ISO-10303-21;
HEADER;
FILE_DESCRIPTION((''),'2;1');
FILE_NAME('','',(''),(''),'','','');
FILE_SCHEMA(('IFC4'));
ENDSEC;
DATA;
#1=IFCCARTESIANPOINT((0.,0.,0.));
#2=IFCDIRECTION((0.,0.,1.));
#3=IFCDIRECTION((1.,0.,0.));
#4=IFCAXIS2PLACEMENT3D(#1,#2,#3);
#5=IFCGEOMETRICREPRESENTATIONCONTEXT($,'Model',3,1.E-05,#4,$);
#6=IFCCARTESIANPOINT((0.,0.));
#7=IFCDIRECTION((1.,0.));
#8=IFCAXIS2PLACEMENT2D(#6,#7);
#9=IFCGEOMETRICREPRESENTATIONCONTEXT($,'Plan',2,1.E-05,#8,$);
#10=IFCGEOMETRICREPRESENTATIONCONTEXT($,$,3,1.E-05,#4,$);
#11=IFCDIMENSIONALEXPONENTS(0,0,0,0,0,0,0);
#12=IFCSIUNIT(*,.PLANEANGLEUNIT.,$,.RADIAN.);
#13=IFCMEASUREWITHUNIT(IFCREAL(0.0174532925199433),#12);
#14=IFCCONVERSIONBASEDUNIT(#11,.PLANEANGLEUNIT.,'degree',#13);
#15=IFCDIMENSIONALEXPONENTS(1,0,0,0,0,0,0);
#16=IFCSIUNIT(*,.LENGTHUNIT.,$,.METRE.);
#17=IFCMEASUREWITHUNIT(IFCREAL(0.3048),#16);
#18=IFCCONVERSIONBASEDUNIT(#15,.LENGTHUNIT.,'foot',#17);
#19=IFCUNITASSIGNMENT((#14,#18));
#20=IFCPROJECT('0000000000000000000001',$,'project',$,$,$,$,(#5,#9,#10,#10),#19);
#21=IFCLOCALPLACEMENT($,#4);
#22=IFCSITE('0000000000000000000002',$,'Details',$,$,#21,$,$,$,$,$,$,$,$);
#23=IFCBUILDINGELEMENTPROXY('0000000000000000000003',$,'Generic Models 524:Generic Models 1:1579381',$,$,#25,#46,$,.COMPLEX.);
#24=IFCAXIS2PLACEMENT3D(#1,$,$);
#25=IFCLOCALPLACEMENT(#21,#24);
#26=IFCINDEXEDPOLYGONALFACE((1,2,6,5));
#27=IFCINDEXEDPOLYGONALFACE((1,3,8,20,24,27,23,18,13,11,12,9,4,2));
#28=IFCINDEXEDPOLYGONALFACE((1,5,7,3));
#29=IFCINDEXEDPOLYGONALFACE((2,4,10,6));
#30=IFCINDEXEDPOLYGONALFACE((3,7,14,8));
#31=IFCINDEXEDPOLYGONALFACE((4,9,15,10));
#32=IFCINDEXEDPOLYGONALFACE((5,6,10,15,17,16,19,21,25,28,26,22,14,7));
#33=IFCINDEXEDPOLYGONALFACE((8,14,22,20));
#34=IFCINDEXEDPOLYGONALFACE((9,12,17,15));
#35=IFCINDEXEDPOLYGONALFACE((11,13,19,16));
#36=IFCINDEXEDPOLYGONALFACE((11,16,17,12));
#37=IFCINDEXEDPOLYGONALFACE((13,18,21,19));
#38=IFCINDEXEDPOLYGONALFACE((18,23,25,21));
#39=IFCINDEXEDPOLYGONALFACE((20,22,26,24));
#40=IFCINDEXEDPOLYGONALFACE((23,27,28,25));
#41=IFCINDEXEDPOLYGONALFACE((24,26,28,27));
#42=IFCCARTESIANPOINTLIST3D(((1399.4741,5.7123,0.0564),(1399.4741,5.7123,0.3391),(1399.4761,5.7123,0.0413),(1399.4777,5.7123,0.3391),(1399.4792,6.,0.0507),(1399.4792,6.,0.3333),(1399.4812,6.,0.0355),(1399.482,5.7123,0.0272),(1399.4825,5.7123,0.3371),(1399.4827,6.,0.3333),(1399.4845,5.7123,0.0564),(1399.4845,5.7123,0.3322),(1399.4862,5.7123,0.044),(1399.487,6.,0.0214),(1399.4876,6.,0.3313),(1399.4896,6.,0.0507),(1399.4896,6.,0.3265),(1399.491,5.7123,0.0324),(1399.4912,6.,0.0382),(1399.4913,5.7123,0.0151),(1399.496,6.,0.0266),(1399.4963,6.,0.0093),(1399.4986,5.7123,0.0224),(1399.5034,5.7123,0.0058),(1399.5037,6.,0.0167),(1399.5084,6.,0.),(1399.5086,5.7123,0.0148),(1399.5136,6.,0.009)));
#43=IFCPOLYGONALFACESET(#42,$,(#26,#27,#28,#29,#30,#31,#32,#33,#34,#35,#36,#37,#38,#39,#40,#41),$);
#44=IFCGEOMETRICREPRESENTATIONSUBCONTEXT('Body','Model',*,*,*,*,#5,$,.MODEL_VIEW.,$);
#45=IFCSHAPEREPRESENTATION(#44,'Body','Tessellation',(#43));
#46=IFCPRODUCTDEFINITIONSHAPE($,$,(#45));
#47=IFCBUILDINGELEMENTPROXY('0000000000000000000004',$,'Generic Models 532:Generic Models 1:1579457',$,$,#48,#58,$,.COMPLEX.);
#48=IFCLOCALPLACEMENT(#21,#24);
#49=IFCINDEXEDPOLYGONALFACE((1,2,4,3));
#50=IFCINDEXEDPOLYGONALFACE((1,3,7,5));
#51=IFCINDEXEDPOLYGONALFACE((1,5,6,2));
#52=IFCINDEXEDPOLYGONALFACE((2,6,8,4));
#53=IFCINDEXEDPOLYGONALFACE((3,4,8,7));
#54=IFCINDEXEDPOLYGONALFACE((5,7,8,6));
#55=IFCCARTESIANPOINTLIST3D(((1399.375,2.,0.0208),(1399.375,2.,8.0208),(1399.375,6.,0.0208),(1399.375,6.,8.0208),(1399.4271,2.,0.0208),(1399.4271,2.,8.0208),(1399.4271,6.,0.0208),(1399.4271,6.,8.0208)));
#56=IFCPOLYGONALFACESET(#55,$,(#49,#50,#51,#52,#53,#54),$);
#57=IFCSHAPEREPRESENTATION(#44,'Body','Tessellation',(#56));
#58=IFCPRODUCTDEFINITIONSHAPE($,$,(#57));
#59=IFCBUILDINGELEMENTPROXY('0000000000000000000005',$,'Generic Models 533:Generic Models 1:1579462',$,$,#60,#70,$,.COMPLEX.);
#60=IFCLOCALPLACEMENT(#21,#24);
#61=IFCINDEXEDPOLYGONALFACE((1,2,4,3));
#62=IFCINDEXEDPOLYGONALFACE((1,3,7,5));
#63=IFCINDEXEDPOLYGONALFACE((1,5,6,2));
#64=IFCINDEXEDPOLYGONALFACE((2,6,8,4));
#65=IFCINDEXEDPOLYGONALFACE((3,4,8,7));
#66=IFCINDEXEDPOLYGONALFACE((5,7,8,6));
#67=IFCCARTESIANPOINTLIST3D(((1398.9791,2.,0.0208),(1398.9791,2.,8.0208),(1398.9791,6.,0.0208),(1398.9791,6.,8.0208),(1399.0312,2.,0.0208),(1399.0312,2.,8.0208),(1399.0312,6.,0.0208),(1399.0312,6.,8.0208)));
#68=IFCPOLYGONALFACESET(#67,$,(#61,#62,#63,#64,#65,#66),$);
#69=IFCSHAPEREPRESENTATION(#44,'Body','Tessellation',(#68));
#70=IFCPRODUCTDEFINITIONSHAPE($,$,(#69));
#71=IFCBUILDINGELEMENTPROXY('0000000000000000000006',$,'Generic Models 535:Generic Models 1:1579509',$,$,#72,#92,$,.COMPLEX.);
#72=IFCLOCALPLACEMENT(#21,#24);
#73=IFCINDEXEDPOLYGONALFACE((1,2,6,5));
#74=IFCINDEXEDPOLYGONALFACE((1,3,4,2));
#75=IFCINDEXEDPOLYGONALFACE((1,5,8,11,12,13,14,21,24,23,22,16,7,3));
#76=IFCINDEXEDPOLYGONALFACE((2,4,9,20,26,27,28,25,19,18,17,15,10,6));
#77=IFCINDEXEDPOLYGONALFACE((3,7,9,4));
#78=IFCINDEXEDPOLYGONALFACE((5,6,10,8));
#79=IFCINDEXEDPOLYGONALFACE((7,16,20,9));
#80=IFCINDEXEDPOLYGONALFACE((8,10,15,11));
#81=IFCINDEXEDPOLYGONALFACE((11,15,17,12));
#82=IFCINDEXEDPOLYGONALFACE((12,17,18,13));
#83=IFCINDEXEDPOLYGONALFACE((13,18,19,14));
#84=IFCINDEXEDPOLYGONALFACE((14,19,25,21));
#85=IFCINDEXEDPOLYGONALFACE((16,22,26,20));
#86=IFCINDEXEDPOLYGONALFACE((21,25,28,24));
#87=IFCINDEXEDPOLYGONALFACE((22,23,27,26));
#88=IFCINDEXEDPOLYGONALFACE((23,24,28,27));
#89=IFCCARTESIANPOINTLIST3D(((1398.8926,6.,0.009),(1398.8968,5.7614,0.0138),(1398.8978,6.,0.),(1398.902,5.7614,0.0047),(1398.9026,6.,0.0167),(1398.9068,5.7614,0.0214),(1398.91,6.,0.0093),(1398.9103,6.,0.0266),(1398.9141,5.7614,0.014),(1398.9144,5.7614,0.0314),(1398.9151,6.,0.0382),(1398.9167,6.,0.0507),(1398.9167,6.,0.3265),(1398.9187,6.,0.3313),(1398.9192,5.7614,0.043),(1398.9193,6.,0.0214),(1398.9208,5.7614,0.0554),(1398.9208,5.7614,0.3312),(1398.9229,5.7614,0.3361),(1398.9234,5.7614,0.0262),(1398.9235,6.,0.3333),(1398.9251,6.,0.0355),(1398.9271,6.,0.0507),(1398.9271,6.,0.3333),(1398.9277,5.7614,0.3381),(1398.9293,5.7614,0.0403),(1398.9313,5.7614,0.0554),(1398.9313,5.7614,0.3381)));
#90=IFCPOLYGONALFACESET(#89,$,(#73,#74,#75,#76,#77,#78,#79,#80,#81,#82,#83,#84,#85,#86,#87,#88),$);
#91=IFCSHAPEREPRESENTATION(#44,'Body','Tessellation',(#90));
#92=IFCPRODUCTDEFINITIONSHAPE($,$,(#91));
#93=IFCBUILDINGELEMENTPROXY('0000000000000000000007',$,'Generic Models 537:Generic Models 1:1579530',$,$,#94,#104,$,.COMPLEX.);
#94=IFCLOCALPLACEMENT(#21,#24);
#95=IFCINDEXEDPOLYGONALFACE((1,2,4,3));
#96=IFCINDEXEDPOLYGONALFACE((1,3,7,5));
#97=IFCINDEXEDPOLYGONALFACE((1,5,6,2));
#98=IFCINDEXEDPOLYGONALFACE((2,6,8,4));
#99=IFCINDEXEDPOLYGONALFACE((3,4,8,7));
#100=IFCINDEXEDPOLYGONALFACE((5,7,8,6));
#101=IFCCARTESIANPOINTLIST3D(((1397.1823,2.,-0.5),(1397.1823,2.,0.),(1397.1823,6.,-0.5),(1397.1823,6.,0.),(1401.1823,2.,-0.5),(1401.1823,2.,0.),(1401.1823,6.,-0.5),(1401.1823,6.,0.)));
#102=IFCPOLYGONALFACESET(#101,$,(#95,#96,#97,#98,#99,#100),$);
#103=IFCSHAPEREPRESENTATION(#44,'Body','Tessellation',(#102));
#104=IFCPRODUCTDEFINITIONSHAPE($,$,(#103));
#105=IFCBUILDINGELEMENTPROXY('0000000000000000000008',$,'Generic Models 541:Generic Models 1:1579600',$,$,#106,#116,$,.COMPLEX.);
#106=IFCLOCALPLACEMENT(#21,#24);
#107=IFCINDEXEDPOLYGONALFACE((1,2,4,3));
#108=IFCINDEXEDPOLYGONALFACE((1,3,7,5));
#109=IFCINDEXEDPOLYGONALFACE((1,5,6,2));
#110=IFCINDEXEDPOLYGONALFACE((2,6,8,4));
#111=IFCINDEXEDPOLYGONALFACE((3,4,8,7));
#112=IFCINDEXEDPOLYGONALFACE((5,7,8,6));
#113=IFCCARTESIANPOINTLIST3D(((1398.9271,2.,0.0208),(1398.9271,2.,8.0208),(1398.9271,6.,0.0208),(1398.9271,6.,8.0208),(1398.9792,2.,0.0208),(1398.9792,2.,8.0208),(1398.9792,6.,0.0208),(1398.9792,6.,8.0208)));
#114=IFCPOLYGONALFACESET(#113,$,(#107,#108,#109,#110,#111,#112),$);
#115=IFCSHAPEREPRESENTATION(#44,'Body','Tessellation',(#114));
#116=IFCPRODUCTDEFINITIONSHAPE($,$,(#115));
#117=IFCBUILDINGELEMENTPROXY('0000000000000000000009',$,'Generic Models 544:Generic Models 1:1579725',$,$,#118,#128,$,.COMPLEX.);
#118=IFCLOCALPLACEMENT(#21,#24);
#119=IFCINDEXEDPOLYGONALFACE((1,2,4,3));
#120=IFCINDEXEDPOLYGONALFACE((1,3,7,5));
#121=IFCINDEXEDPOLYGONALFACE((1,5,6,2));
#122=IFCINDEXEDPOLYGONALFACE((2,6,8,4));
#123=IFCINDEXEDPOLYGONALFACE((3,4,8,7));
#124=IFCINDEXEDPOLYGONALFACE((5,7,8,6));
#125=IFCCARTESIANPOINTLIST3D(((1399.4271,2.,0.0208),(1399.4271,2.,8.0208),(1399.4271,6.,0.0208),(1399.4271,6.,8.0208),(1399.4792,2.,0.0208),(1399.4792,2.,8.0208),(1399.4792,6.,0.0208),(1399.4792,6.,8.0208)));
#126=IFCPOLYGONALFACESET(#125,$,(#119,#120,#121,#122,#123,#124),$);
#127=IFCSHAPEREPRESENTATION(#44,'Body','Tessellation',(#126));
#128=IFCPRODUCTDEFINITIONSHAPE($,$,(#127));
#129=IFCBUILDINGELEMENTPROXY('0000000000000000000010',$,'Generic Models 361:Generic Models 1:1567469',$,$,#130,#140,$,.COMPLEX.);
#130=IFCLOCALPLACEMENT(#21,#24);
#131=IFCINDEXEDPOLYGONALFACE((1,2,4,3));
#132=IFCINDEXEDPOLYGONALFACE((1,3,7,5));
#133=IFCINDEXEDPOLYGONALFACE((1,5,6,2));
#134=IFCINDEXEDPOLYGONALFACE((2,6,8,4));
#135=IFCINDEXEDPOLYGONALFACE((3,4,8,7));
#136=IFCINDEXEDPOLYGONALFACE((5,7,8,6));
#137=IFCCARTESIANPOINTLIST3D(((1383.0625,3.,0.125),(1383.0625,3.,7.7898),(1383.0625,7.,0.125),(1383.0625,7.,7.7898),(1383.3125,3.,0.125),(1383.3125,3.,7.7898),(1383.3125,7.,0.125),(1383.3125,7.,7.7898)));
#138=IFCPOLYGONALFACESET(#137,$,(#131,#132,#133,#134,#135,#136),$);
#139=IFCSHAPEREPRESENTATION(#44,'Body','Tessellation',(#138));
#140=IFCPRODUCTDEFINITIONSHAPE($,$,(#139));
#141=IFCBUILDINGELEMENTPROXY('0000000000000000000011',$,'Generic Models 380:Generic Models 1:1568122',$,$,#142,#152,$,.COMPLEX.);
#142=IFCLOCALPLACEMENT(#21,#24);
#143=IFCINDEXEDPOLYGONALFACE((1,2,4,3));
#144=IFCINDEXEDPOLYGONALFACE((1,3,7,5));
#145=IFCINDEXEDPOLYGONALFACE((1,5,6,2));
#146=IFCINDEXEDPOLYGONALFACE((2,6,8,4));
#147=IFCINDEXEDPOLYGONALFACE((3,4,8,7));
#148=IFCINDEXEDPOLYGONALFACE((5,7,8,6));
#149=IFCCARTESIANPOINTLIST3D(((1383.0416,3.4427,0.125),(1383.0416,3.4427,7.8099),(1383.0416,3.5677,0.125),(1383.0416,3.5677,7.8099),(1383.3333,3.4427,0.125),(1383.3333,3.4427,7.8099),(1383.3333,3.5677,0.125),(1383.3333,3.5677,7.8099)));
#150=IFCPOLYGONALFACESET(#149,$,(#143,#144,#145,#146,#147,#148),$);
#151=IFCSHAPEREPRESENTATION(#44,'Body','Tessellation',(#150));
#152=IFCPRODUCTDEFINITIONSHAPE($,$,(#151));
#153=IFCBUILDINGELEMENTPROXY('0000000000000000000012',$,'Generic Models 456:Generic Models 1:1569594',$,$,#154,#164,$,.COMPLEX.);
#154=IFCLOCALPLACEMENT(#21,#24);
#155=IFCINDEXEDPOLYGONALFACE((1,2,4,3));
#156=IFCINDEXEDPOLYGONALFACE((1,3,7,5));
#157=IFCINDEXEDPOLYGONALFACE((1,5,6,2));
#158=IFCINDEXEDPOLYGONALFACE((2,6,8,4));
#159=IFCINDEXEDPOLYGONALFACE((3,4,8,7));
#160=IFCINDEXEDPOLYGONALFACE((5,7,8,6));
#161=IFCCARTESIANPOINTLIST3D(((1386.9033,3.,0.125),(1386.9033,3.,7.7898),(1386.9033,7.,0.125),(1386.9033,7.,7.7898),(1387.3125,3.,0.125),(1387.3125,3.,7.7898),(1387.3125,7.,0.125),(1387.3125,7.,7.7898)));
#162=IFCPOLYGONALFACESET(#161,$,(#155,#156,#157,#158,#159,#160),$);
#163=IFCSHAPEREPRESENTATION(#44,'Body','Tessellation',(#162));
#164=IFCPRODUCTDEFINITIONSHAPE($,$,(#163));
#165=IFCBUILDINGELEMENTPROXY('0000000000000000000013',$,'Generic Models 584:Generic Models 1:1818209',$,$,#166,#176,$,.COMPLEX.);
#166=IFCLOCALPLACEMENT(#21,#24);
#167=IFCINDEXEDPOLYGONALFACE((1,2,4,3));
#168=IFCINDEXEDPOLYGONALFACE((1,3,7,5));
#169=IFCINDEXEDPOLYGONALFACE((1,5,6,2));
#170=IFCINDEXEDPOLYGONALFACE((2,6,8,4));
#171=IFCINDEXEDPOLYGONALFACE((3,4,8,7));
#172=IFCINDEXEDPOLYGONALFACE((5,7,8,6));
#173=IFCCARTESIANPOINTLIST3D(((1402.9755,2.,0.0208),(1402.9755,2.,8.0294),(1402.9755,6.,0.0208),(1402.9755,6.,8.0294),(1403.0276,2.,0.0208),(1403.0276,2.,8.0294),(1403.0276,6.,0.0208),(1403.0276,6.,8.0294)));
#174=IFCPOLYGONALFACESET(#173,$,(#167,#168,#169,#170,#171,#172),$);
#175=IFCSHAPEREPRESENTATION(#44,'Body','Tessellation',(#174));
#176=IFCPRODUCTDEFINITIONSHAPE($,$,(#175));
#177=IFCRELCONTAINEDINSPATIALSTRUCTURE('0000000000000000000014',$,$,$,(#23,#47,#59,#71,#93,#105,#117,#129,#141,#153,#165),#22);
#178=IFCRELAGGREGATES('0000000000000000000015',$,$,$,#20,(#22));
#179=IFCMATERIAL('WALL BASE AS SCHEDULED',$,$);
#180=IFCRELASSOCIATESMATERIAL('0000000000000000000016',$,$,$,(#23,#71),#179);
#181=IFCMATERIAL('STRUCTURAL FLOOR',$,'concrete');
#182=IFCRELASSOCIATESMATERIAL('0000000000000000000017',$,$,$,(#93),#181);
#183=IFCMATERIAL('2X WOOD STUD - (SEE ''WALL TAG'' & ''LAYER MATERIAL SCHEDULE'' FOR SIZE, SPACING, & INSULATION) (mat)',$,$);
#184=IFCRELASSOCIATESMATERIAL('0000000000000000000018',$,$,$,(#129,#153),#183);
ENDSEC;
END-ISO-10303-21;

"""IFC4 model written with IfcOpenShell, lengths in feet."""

from ifc_helpers import new_model, entity, si_unit, converted_unit, frame, origin_with_axes, origin_2d_with_axis, place, context, subcontext, project, spatial, polyline, line, indexed_curve, outline, extrude, material, element, save


model = new_model("IFC4")

# Units and contexts
model_context = context("Model", 3, precision=1e-05, world=origin_with_axes())
plan_context = context("Plan", 2, precision=1e-05, world=origin_2d_with_axis())
context_of_model = context(None, 3, precision=1e-05, world=origin_with_axes())
body_context = subcontext(model_context, "Body", "Model", "MODEL_VIEW")
ifc_project = project(units=[converted_unit("PLANEANGLEUNIT", "degree", entity("IfcReal", 0.0174532925199433), si_unit("PLANEANGLEUNIT", "RADIAN"), dimensions=[0, 0, 0, 0, 0, 0, 0]), converted_unit("LENGTHUNIT", "foot", entity("IfcReal", 0.3048), si_unit("LENGTHUNIT", "METRE"), dimensions=[1, 0, 0, 0, 0, 0, 0])], contexts=[model_context, plan_context, context_of_model, context_of_model])

# Site
site_placement = place(None, origin_with_axes())
site = spatial("IfcSite", under=ifc_project, at=site_placement, Name="Details")

# Building element proxies
ifc_material_1 = material(Name="WALL BASE AS SCHEDULED")
proxy_1_placement = place(site_placement, frame((1399.4792, 6.0, 0.0), z_axis=(0.0, -1.0, 0.0), x_axis=(0.0, 0.0, 1.0)))
element("IfcBuildingElementProxy", 1, at=proxy_1_placement, inside=site, material=ifc_material_1, Name="Generic Models 524:Generic Models 1:1579381", PredefinedType="COMPLEX", context=body_context, shape_type="SweptSolid", body=[
    extrude(outline(polyline([(0.0865, 0.0), (0.0968, -0.0072), (0.105, -0.0167), (0.1137, -0.0111), (0.1038, 0.0006), (0.0913, 0.0093), (0.0769, 0.0144), (0.0617, 0.0157), (-0.2206, 0.0019), (-0.2205, -0.0017), (-0.2182, -0.0064), (-0.2133, -0.0082), (0.0622, 0.0053), (0.0747, 0.0042), (0.0865, 0.0)])), frame((0.113, -0.0126, 0.0), z_axis=(0.0, 0.0, -1.0), x_axis=(-0.998808, -0.048806, 0.0)), (-0.020832, 0.016543, -0.999646), 0.2878),
])
proxy_2_placement = place(site_placement, frame((1399.375, 6.0, 0.0208), z_axis=(0.0, -1.0, 0.0), x_axis=(0.0, 0.0, 1.0)))
element("IfcBuildingElementProxy", 2, at=proxy_2_placement, inside=site, Name="Generic Models 532:Generic Models 1:1579457", PredefinedType="COMPLEX", context=body_context, shape_type="SweptSolid", body=[
    extrude(outline(polyline([(-4.0, -0.026), (4.0, -0.026), (4.0, 0.026), (-4.0, 0.026), (-4.0, -0.026)])), frame((4.0, -0.026, 0.0), z_axis=(0.0, 0.0, -1.0), x_axis=(1.0, 0.0, 0.0)), (0.0, 0.0, -1.0), 4.0),
])
proxy_3_placement = place(site_placement, frame((1398.9791, 6.0, 0.0208), z_axis=(0.0, -1.0, 0.0), x_axis=(0.0, 0.0, 1.0)))
element("IfcBuildingElementProxy", 3, at=proxy_3_placement, inside=site, Name="Generic Models 533:Generic Models 1:1579462", PredefinedType="COMPLEX", context=body_context, shape_type="SweptSolid", body=[
    extrude(outline(polyline([(-0.026, -4.0), (0.026, -4.0), (0.026, 4.0), (-0.026, 4.0), (-0.026, -4.0)])), frame((4.0, -0.026, 0.0), z_axis=(0.0, 0.0, -1.0), x_axis=(0.0, -1.0, 0.0)), (0.0, 0.0, -1.0), 4.0),
])
proxy_4_placement = place(site_placement, frame((1398.8926, 6.0, 0.0), z_axis=(0.0, -1.0, 0.0), x_axis=(0.0, 0.0, 1.0)))
element("IfcBuildingElementProxy", 4, at=proxy_4_placement, inside=site, material=ifc_material_1, Name="Generic Models 535:Generic Models 1:1579509", PredefinedType="COMPLEX", context=body_context, shape_type="SweptSolid", body=[
    extrude(outline(polyline([(-0.2203, -0.0126), (0.0624, -0.0126), (0.0775, -0.0106), (0.0916, -0.0048), (0.1037, 0.0045), (0.113, 0.0166), (0.104, 0.0218), (0.0964, 0.0119), (0.0864, 0.0042), (0.0748, -0.0006), (0.0624, -0.0022), (-0.2134, -0.0022), (-0.2183, -0.0042), (-0.2203, -0.0091), (-0.2203, -0.0126)])), frame((0.113, -0.0218, 0.0), z_axis=(0.0, 0.0, -1.0), x_axis=(-1.0, 0.0, 0.0)), (-0.01982, -0.017382, -0.999652), 0.2387),
])
ifc_material_2 = material(Name="STRUCTURAL FLOOR", Category="concrete")
proxy_5_placement = place(site_placement, frame((1397.1823, 6.0, -0.5), z_axis=(0.0, -1.0, 0.0), x_axis=(0.0, 0.0, 1.0)))
element("IfcBuildingElementProxy", 5, at=proxy_5_placement, inside=site, material=ifc_material_2, Name="Generic Models 537:Generic Models 1:1579530", PredefinedType="COMPLEX", context=body_context, shape_type="SweptSolid", body=[
    extrude(outline(polyline([(-0.25, -2.0), (0.25, -2.0), (0.25, 2.0), (-0.25, 2.0), (-0.25, -2.0)])), frame((0.25, -2.0, 0.0), z_axis=(0.0, 0.0, -1.0), x_axis=(1.0, 0.0, 0.0)), (0.0, 0.0, -1.0), 4.0),
])
proxy_6_placement = place(site_placement, frame((1398.9271, 6.0, 0.0208), z_axis=(0.0, -1.0, 0.0), x_axis=(0.0, 0.0, 1.0)))
element("IfcBuildingElementProxy", 6, at=proxy_6_placement, inside=site, Name="Generic Models 541:Generic Models 1:1579600", PredefinedType="COMPLEX", context=body_context, shape_type="SweptSolid", body=[
    extrude(outline(polyline([(-4.0, -0.026), (4.0, -0.026), (4.0, 0.026), (-4.0, 0.026), (-4.0, -0.026)])), frame((4.0, -0.026, 0.0), z_axis=(0.0, 0.0, -1.0), x_axis=(1.0, 0.0, 0.0)), (0.0, 0.0, -1.0), 4.0),
])
proxy_7_placement = place(site_placement, frame((1399.4271, 6.0, 0.0208), z_axis=(0.0, -1.0, 0.0), x_axis=(0.0, 0.0, 1.0)))
element("IfcBuildingElementProxy", 7, at=proxy_7_placement, inside=site, Name="Generic Models 544:Generic Models 1:1579725", PredefinedType="COMPLEX", context=body_context, shape_type="SweptSolid", body=[
    extrude(outline(indexed_curve([(-4.0, -0.026), (4.0, -0.026), (4.0, 0.026), (-4.0, 0.026)], segments=[line(3, 2), line(2, 1), line(1, 4), line(4, 3)], self_intersect=False)), frame((4.0, -0.026, 0.0), z_axis=(0.0, 0.0, -1.0), x_axis=(1.0, 0.0, 0.0)), (0.0, 0.0, -1.0), 4.0),
])
ifc_material_3 = material(Name="2X WOOD STUD - (SEE 'WALL TAG' & 'LAYER MATERIAL SCHEDULE' FOR SIZE, SPACING, & INSULATION) (mat)")
proxy_8_placement = place(site_placement, frame((1383.0625, 7.0, 0.125), z_axis=(0.0, -1.0, 0.0), x_axis=(0.0, 0.0, 1.0)))
element("IfcBuildingElementProxy", 8, at=proxy_8_placement, inside=site, material=ifc_material_3, Name="Generic Models 361:Generic Models 1:1567469", PredefinedType="COMPLEX", context=body_context, shape_type="SweptSolid", body=[
    extrude(outline(polyline([(-0.125, -3.8324), (0.125, -3.8324), (0.125, 3.8324), (-0.125, 3.8324), (-0.125, -3.8324)])), frame((3.8324, -0.125, 0.0), z_axis=(0.0, 0.0, -1.0), x_axis=(0.0, -1.0, 0.0)), (0.0, 0.0, -1.0), 4.0),
])
proxy_9_placement = place(site_placement, frame((1383.0416, 7.4427, 0.125), z_axis=(0.0, -1.0, 0.0), x_axis=(1.0, 0.0, 0.0)))
element("IfcBuildingElementProxy", 9, at=proxy_9_placement, inside=site, Name="Generic Models 380:Generic Models 1:1568122", PredefinedType="COMPLEX", context=body_context, shape_type="SweptSolid", body=[
    extrude(outline(polyline([(-0.1458, -3.8424), (0.1458, -3.8424), (0.1458, 3.8424), (-0.1458, 3.8424), (-0.1458, -3.8424)])), frame((0.1458, 3.8424, 3.875), z_axis=(0.0, 0.0, -1.0), x_axis=(-1.0, 0.0, 0.0)), (0.0, 0.000002, -1.0), 0.125),
])
proxy_10_placement = place(site_placement, frame((1386.9033, 7.0, 0.125), z_axis=(0.0, -1.0, 0.0), x_axis=(0.0, 0.0, 1.0)))
element("IfcBuildingElementProxy", 10, at=proxy_10_placement, inside=site, material=ifc_material_3, Name="Generic Models 456:Generic Models 1:1569594", PredefinedType="COMPLEX", context=body_context, shape_type="SweptSolid", body=[
    extrude(outline(polyline([(-0.2046, -3.8324), (0.2046, -3.8324), (0.2046, 3.8324), (-0.2046, 3.8324), (-0.2046, -3.8324)])), frame((3.8324, -0.2046, 0.0), z_axis=(0.0, 0.0, -1.0), x_axis=(0.0, -1.0, 0.0)), (0.0, 0.0, -1.0), 4.0),
])
proxy_11_placement = place(site_placement, frame((1402.9755, 6.0, 0.0208), z_axis=(0.0, -1.0, 0.0), x_axis=(0.0, 0.0, 1.0)))
element("IfcBuildingElementProxy", 11, at=proxy_11_placement, inside=site, Name="Generic Models 584:Generic Models 1:1818209", PredefinedType="COMPLEX", context=body_context, shape_type="SweptSolid", body=[
    extrude(outline(polyline([(-0.026, -4.0043), (0.026, -4.0043), (0.026, 4.0043), (-0.026, 4.0043), (-0.026, -4.0043)])), frame((4.0043, -0.026, 0.0), z_axis=(0.0, 0.0, -1.0), x_axis=(0.0, 1.0, 0.0)), (0.0, 0.0, -1.0), 4.0),
])

save(model, "model.ifc")
